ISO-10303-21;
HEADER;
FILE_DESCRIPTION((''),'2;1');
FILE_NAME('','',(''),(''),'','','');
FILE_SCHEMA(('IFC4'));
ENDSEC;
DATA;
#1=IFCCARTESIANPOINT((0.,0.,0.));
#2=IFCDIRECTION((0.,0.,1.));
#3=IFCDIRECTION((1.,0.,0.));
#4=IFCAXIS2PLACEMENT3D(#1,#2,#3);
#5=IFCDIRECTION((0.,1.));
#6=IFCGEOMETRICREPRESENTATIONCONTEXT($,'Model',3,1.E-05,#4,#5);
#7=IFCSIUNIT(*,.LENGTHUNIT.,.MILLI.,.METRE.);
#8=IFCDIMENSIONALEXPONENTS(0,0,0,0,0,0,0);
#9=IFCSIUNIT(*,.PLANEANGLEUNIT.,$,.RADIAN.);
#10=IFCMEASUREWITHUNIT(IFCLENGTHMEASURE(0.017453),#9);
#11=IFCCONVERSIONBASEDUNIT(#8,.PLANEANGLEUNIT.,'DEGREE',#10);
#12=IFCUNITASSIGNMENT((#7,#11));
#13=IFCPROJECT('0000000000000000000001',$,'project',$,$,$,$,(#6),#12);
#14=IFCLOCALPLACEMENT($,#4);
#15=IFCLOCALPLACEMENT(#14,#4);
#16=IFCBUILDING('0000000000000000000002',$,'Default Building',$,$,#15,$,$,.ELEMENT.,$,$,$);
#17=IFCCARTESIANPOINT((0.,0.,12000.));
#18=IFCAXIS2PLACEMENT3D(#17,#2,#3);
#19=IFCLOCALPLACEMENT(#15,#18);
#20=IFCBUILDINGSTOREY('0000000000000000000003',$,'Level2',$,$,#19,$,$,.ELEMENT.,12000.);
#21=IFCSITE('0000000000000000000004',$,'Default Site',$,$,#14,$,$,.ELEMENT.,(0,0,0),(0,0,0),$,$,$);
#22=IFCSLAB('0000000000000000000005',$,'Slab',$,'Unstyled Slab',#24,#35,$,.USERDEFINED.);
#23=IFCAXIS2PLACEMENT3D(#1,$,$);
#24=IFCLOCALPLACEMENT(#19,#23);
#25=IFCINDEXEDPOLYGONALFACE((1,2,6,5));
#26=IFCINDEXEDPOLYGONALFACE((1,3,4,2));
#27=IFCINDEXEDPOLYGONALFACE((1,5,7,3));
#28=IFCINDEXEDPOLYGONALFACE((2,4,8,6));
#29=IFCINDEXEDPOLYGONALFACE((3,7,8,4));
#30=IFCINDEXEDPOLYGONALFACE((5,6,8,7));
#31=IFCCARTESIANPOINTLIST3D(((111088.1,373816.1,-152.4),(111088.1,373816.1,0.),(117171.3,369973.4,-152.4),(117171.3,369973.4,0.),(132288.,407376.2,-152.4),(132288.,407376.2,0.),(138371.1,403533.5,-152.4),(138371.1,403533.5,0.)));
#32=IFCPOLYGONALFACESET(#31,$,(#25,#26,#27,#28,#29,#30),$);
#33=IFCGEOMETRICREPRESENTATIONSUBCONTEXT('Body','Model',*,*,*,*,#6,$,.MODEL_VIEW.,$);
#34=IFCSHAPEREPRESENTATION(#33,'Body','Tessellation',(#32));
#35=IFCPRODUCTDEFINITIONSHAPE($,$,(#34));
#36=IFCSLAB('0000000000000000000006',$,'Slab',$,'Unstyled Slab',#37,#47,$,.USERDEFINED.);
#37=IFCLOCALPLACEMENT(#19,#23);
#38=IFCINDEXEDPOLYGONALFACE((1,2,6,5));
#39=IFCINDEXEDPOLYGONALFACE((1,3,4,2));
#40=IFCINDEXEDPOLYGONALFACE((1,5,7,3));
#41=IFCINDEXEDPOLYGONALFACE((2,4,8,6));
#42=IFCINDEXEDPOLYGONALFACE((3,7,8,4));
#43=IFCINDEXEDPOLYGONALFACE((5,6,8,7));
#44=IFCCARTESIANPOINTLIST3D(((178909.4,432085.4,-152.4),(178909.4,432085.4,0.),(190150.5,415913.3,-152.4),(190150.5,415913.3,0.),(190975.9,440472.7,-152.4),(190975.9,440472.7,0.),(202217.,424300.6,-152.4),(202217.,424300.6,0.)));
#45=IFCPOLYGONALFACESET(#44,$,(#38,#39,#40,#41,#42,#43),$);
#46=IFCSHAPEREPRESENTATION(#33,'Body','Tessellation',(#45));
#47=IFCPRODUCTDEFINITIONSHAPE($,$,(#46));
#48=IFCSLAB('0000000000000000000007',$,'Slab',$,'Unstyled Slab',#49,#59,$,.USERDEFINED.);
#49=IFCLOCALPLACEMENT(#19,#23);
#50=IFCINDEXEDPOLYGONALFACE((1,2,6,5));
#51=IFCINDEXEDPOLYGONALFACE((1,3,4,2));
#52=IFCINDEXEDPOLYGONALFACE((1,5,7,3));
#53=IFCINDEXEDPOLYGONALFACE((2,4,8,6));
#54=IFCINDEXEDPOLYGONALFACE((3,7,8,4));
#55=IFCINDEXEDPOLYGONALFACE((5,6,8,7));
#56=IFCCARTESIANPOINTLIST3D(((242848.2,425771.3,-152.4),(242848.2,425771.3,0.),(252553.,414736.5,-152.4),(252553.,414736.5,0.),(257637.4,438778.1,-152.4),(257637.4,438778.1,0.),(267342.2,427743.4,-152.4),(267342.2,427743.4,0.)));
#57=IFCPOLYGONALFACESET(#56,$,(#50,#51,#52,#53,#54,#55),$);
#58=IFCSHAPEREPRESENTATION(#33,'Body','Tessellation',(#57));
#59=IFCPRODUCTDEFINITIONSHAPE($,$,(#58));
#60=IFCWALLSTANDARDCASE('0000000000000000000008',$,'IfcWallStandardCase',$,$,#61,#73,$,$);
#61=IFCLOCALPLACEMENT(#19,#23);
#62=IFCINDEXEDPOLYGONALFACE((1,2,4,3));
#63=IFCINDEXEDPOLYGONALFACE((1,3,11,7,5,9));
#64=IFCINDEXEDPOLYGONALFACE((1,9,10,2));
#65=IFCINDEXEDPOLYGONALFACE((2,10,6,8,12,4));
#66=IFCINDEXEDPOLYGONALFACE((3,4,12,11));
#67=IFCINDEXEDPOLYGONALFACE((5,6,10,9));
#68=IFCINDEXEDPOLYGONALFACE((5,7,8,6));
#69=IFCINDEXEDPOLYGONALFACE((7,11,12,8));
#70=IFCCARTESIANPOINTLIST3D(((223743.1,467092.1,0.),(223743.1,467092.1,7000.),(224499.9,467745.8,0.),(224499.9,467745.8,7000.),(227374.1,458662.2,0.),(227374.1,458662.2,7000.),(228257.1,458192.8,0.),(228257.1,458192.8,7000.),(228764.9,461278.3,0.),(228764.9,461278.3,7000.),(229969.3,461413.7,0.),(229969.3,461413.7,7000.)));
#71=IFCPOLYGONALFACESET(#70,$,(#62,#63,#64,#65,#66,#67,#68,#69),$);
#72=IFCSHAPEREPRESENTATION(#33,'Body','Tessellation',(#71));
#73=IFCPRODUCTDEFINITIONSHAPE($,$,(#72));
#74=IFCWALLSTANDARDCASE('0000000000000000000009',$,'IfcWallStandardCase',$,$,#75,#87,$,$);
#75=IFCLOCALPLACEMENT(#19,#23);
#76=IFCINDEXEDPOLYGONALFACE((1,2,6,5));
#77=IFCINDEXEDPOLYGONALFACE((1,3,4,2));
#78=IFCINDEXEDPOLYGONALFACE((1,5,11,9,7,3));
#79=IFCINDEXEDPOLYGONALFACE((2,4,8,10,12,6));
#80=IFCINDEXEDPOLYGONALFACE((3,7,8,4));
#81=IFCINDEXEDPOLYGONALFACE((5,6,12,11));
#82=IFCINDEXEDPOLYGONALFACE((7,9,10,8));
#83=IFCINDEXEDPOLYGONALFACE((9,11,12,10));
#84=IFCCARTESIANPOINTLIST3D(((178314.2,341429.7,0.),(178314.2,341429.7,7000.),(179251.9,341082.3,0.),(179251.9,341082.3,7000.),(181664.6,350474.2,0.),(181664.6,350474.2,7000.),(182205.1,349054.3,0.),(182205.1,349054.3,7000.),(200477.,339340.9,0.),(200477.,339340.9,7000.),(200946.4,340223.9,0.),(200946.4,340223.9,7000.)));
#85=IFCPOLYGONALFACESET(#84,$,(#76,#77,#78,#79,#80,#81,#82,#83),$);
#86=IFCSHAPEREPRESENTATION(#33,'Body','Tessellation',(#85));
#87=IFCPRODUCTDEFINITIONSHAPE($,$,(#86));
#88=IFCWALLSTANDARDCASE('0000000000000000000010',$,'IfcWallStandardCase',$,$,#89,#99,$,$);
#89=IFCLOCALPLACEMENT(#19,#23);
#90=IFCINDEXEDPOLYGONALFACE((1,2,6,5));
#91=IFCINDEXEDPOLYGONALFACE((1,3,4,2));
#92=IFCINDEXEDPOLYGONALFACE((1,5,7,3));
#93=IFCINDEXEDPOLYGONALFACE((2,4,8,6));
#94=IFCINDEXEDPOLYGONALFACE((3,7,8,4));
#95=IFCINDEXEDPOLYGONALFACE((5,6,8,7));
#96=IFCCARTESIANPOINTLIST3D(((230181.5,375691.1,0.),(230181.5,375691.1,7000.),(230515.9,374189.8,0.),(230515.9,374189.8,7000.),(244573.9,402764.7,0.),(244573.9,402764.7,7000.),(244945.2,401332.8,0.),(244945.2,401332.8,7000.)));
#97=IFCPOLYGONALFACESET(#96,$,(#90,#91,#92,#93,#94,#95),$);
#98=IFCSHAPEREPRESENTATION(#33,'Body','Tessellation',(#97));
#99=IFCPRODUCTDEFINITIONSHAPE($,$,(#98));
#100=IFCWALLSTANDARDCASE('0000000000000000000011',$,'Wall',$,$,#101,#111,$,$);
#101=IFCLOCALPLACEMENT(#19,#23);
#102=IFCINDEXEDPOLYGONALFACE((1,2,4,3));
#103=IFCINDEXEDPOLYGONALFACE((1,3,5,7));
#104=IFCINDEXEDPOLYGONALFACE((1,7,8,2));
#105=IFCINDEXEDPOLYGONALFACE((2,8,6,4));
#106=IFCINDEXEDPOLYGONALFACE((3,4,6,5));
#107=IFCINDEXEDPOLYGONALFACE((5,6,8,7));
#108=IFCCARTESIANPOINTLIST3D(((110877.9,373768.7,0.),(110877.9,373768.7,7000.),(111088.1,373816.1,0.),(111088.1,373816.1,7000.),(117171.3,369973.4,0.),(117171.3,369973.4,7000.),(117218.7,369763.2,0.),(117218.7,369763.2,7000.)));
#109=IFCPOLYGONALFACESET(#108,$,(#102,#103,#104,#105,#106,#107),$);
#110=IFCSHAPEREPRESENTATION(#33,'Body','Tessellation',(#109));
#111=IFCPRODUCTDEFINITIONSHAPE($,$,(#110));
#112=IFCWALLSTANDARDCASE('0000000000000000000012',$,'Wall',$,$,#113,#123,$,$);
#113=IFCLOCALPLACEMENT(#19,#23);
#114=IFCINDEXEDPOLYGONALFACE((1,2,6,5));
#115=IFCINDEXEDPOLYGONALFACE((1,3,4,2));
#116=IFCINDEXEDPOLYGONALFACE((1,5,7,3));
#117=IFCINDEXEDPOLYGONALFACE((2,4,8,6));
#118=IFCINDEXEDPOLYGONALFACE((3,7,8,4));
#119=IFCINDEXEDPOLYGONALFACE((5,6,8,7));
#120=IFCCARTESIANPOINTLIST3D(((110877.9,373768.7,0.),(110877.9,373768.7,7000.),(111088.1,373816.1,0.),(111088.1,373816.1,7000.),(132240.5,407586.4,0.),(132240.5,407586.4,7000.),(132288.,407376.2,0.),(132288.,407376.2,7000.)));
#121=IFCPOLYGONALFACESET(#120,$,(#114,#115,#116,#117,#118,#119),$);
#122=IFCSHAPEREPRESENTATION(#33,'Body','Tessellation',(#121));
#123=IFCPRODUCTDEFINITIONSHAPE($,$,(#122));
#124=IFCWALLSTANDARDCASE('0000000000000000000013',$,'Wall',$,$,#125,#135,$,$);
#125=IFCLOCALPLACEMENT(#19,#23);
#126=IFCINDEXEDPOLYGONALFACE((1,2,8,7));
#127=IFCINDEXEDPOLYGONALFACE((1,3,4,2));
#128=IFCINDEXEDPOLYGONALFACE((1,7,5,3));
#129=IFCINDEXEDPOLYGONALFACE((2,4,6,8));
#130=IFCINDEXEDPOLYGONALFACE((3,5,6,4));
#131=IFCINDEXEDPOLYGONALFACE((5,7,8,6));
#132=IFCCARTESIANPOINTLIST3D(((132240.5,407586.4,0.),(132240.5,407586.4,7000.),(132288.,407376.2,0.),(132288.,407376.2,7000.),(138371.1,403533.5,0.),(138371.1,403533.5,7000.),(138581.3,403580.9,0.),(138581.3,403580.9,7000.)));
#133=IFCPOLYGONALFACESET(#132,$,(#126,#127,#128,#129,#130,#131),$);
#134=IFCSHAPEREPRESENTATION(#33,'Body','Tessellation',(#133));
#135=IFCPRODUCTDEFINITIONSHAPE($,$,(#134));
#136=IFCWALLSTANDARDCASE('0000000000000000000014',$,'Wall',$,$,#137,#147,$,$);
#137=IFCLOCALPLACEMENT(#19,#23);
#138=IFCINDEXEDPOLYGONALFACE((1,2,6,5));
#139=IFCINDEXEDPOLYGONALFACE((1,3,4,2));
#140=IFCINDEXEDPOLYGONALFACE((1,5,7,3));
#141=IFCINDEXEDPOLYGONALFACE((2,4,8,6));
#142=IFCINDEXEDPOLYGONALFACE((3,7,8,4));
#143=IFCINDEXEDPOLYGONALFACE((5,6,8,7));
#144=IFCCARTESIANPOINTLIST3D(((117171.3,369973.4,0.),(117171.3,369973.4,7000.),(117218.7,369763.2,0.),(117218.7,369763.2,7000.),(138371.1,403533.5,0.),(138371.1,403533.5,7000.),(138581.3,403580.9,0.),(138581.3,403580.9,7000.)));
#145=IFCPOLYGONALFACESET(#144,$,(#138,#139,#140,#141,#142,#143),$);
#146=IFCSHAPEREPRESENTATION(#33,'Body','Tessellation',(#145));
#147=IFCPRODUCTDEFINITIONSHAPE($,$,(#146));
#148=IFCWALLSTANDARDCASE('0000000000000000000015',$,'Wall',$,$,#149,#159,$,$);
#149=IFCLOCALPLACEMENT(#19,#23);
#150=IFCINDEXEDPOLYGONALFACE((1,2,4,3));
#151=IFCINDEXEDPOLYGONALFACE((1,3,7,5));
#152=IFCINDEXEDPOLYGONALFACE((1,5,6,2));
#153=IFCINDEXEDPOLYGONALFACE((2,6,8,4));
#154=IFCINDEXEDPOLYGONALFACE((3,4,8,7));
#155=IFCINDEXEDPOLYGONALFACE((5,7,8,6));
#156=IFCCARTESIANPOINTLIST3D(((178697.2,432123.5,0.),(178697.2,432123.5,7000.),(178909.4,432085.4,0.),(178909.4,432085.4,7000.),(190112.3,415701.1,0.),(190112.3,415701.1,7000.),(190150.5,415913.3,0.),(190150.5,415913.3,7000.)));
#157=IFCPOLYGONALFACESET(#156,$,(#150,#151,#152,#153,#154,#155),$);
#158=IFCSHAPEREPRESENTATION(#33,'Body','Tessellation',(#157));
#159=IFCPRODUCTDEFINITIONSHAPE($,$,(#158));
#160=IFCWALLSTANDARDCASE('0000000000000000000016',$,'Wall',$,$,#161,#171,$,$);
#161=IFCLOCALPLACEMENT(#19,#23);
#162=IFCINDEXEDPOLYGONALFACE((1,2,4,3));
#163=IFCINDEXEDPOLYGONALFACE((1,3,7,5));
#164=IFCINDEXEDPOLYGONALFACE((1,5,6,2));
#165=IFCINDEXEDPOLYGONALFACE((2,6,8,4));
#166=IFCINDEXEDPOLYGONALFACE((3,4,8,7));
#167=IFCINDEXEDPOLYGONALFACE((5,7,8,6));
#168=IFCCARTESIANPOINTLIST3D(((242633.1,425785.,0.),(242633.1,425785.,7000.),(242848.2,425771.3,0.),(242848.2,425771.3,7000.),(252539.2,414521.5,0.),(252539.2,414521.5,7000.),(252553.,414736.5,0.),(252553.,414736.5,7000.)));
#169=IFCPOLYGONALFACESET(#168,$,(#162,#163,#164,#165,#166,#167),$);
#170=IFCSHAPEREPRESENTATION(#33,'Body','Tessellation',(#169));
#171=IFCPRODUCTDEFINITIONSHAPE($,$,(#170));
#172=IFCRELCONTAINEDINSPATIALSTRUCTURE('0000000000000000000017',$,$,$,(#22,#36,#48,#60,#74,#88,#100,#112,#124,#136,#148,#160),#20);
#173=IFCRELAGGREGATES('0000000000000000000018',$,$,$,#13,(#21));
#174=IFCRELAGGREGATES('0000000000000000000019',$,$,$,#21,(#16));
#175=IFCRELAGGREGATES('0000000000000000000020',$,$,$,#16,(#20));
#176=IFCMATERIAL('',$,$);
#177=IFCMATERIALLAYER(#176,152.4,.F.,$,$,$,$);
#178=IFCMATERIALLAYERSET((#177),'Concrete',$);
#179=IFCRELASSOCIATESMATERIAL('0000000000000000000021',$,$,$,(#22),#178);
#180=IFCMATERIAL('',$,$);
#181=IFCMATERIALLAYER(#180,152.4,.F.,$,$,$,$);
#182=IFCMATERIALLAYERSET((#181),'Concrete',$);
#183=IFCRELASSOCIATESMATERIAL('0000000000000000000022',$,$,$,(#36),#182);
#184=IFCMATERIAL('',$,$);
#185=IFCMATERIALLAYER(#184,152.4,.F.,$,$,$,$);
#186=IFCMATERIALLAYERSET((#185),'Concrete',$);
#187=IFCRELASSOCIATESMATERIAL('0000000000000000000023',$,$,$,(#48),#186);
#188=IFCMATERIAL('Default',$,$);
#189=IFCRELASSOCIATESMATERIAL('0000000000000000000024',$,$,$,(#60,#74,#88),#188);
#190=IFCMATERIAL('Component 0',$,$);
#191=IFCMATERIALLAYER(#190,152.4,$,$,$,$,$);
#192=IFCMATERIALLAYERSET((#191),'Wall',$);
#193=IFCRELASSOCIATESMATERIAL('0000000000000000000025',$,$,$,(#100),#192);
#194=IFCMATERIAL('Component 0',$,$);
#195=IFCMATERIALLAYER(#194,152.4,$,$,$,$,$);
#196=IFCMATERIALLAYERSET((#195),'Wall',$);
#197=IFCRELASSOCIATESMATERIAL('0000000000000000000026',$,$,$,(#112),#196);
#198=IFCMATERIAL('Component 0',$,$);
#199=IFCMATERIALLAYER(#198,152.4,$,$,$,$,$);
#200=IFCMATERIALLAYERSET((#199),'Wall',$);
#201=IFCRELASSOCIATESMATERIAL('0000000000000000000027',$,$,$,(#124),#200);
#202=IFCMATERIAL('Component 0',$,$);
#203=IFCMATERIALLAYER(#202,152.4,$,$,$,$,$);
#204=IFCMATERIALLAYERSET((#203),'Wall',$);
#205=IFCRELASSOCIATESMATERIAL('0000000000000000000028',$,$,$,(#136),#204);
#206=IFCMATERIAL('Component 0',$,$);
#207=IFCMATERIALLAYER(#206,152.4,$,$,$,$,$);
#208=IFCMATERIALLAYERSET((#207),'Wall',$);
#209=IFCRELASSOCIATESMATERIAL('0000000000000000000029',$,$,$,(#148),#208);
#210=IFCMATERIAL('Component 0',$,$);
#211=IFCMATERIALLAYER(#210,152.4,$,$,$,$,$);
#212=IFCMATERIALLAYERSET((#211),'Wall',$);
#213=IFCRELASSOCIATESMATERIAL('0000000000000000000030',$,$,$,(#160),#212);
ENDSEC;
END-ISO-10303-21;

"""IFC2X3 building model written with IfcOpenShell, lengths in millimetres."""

from ifc_helpers import new_model, entity, si_unit, converted_unit, direction, frame, origin_with_axes, place, context, subcontext, project, spatial, polyline, outline, extrude, material, layer, layer_set, layer_usage, element, save


model = new_model("IFC2X3")

# Units and contexts
model_context = context("Model", 3, precision=1e-05, world=origin_with_axes(), true_north=direction((0.0, 1.0)))
body_context = subcontext(model_context, "Body", "Model", "MODEL_VIEW")
ifc_project = project(units=[si_unit("LENGTHUNIT", "METRE", prefix="MILLI"), converted_unit("PLANEANGLEUNIT", "DEGREE", entity("IfcLengthMeasure", 0.017453), si_unit("PLANEANGLEUNIT", "RADIAN"), dimensions=[0, 0, 0, 0, 0, 0, 0])], contexts=[model_context])

# Site, building, storey
site_placement = place(None, origin_with_axes())
site = spatial("IfcSite", under=ifc_project, at=site_placement, Name="Default Site", CompositionType="ELEMENT", RefLatitude=(0, 0, 0), RefLongitude=(0, 0, 0))
building_placement = place(site_placement, origin_with_axes())
building = spatial("IfcBuilding", under=site, at=building_placement, Name="Default Building", CompositionType="ELEMENT")
storey_placement = place(building_placement, frame((0.0, 0.0, 12000.0), z_axis=(0.0, 0.0, 1.0), x_axis=(1.0, 0.0, 0.0)))
storey = spatial("IfcBuildingStorey", under=building, at=storey_placement, Name="Level2", CompositionType="ELEMENT", Elevation=12000.0)

# Slabs
ifc_material_1 = material(Name="")
ifc_layer_1 = layer(ifc_material_1, 152.4, ventilated=False)
ifc_layer_set_1 = layer_set([ifc_layer_1], Name="Concrete")
ifc_layer_usage_1 = layer_usage(ifc_layer_set_1, "AXIS3", "NEGATIVE", 0.0)
slab_1_placement = place(storey_placement, frame((0.0, 0.0, -12000.0), z_axis=(0.0, 0.0, 1.0), x_axis=(1.0, 0.0, 0.0)))
element("IfcSlab", 1, at=slab_1_placement, inside=storey, material=ifc_layer_usage_1, Name="Slab", ObjectType="Unstyled Slab", PredefinedType="USERDEFINED", context=body_context, shape_type="SweptSolid", body=[
    extrude(outline(polyline([(0.0, 39695.2), (7195.2, 39695.2), (7195.2, 0.0), (0.0, 0.0), (0.0, 39695.2)])), frame((117171.3, 369973.4, 11847.6), z_axis=(0.0, 0.0, -1.0), x_axis=(-0.845443, 0.534065, 0.0)), (0.0, 0.0, -1.0), 152.4),
])
ifc_material_2 = material(Name="")
ifc_layer_2 = layer(ifc_material_2, 152.4, ventilated=False)
ifc_layer_set_2 = layer_set([ifc_layer_2], Name="Concrete")
ifc_layer_usage_2 = layer_usage(ifc_layer_set_2, "AXIS3", "NEGATIVE", 0.0)
slab_2_placement = place(storey_placement, frame((0.0, 0.0, -12000.0), z_axis=(0.0, 0.0, 1.0), x_axis=(1.0, 0.0, 0.0)))
element("IfcSlab", 2, at=slab_2_placement, inside=storey, material=ifc_layer_usage_2, Name="Slab", ObjectType="Unstyled Slab", PredefinedType="USERDEFINED", context=body_context, shape_type="SweptSolid", body=[
    extrude(outline(polyline([(0.0, 19695.2), (14695.2, 19695.2), (14695.2, 0.0), (0.0, 0.0), (0.0, 19695.2)])), frame((178909.4, 432085.4, 11847.6), z_axis=(0.0, 0.0, -1.0), x_axis=(0.82112, 0.570755, 0.0)), (0.0, 0.0, -1.0), 152.4),
])
ifc_material_3 = material(Name="")
ifc_layer_3 = layer(ifc_material_3, 152.4, ventilated=False)
ifc_layer_set_3 = layer_set([ifc_layer_3], Name="Concrete")
ifc_layer_usage_3 = layer_usage(ifc_layer_set_3, "AXIS3", "NEGATIVE", 0.0)
slab_3_placement = place(storey_placement, frame((0.0, 0.0, -12000.0), z_axis=(0.0, 0.0, 1.0), x_axis=(1.0, 0.0, 0.0)))
element("IfcSlab", 3, at=slab_3_placement, inside=storey, material=ifc_layer_usage_3, Name="Slab", ObjectType="Unstyled Slab", PredefinedType="USERDEFINED", context=body_context, shape_type="SweptSolid", body=[
    extrude(outline(polyline([(0.0, 19695.2), (14695.2, 19695.2), (14695.2, 0.0), (0.0, 0.0), (0.0, 19695.2)])), frame((252553.0, 414736.5, 11847.6), z_axis=(0.0, 0.0, -1.0), x_axis=(-0.660409, 0.750906, 0.0)), (0.0, 0.0, -1.0), 152.4),
])

# Walls
ifc_material_4 = material(Name="Default")
wall_1_placement = place(storey_placement, frame((0.0, 0.0, -12000.0), z_axis=(0.0, 0.0, 1.0), x_axis=(1.0, 0.0, 0.0)))
element("IfcWallStandardCase", 4, at=wall_1_placement, inside=storey, material=ifc_material_4, Name="IfcWallStandardCase", context=body_context, shape_type="SweptSolid", body=[
    extrude(outline(polyline([(227374.1, 458662.2), (228764.9, 461278.3), (223743.1, 467092.1), (224499.9, 467745.8), (229969.3, 461413.7), (228257.1, 458192.8), (227374.1, 458662.2)])), frame((0.0, 0.0, 12000.0), z_axis=(0.0, 0.0, 1.0), x_axis=(1.0, 0.0, 0.0)), (0.0, 0.0, 1.0), 7000.0),
])
wall_2_placement = place(storey_placement, frame((0.0, 0.0, -12000.0), z_axis=(0.0, 0.0, 1.0), x_axis=(1.0, 0.0, 0.0)))
element("IfcWallStandardCase", 5, at=wall_2_placement, inside=storey, material=ifc_material_4, Name="IfcWallStandardCase", context=body_context, shape_type="SweptSolid", body=[
    extrude(outline(polyline([(178314.2, 341429.7), (181664.6, 350474.2), (200946.4, 340223.9), (200477.0, 339340.9), (182205.1, 349054.3), (179251.9, 341082.3), (178314.2, 341429.7)])), frame((0.0, 0.0, 12000.0), z_axis=(0.0, 0.0, 1.0), x_axis=(1.0, 0.0, 0.0)), (0.0, 0.0, 1.0), 7000.0),
])
wall_3_placement = place(storey_placement, frame((0.0, 0.0, -12000.0), z_axis=(0.0, 0.0, 1.0), x_axis=(1.0, 0.0, 0.0)))
element("IfcWallStandardCase", 6, at=wall_3_placement, inside=storey, material=ifc_material_4, Name="IfcWallStandardCase", context=body_context, shape_type="SweptSolid", body=[
    extrude(outline(polyline([(244945.2, 401332.8), (244573.9, 402764.7), (230181.5, 375691.1), (230515.9, 374189.8), (244945.2, 401332.8)])), frame((0.0, 0.0, 12000.0), z_axis=(0.0, 0.0, 1.0), x_axis=(1.0, 0.0, 0.0)), (0.0, 0.0, 1.0), 7000.0),
])
ifc_material_5 = material(Name="Component 0")
ifc_layer_4 = layer(ifc_material_5, 152.4)
ifc_layer_set_4 = layer_set([ifc_layer_4], Name="Wall")
ifc_layer_usage_4 = layer_usage(ifc_layer_set_4, "AXIS2", "POSITIVE", -76.2)
wall_4_placement = place(storey_placement, frame((117195.0, 369868.3, 0.0), z_axis=(0.0, 0.0, 1.0), x_axis=(-0.845443, 0.534065, 0.0)))
element("IfcWallStandardCase", 7, at=wall_4_placement, inside=storey, material=ifc_layer_usage_4, Name="Wall", context=body_context, shape_type="SweptSolid", body=[
    extrude(outline(polyline([(76.2, -76.2), (-76.2, 76.2), (7423.8, 76.2), (7271.4, -76.2), (76.2, -76.2)])), origin_with_axes(), (0.0, 0.0, 1.0), 7000.0),
])
ifc_material_6 = material(Name="Component 0")
ifc_layer_5 = layer(ifc_material_6, 152.4)
ifc_layer_set_5 = layer_set([ifc_layer_5], Name="Wall")
ifc_layer_usage_5 = layer_usage(ifc_layer_set_5, "AXIS2", "POSITIVE", -76.2)
wall_5_placement = place(storey_placement, frame((110983.0, 373792.4, 0.0), z_axis=(0.0, 0.0, 1.0), x_axis=(0.534065, 0.845443, 0.0)))
element("IfcWallStandardCase", 8, at=wall_5_placement, inside=storey, material=ifc_layer_usage_5, Name="Wall", context=body_context, shape_type="SweptSolid", body=[
    extrude(outline(polyline([(76.2, -76.2), (-76.2, 76.2), (39923.8, 76.2), (39771.4, -76.2), (76.2, -76.2)])), origin_with_axes(), (0.0, 0.0, 1.0), 7000.0),
])
ifc_material_7 = material(Name="Component 0")
ifc_layer_6 = layer(ifc_material_7, 152.4)
ifc_layer_set_6 = layer_set([ifc_layer_6], Name="Wall")
ifc_layer_usage_6 = layer_usage(ifc_layer_set_6, "AXIS2", "POSITIVE", -76.2)
wall_6_placement = place(storey_placement, frame((132264.2, 407481.3, 0.0), z_axis=(0.0, 0.0, 1.0), x_axis=(0.845443, -0.534065, 0.0)))
element("IfcWallStandardCase", 9, at=wall_6_placement, inside=storey, material=ifc_layer_usage_6, Name="Wall", context=body_context, shape_type="SweptSolid", body=[
    extrude(outline(polyline([(76.2, -76.2), (-76.2, 76.2), (7423.8, 76.2), (7271.4, -76.2), (76.2, -76.2)])), origin_with_axes(), (0.0, 0.0, 1.0), 7000.0),
])
ifc_material_8 = material(Name="Component 0")
ifc_layer_7 = layer(ifc_material_8, 152.4)
ifc_layer_set_7 = layer_set([ifc_layer_7], Name="Wall")
ifc_layer_usage_7 = layer_usage(ifc_layer_set_7, "AXIS2", "POSITIVE", -76.2)
wall_7_placement = place(storey_placement, frame((138476.2, 403557.2, 0.0), z_axis=(0.0, 0.0, 1.0), x_axis=(-0.534065, -0.845443, 0.0)))
element("IfcWallStandardCase", 10, at=wall_7_placement, inside=storey, material=ifc_layer_usage_7, Name="Wall", context=body_context, shape_type="SweptSolid", body=[
    extrude(outline(polyline([(76.2, -76.2), (-76.2, 76.2), (39923.8, 76.2), (39771.4, -76.2), (76.2, -76.2)])), origin_with_axes(), (0.0, 0.0, 1.0), 7000.0),
])
ifc_material_9 = material(Name="Component 0")
ifc_layer_8 = layer(ifc_material_9, 152.4)
ifc_layer_set_8 = layer_set([ifc_layer_8], Name="Wall")
ifc_layer_usage_8 = layer_usage(ifc_layer_set_8, "AXIS2", "POSITIVE", -76.2)
wall_8_placement = place(storey_placement, frame((190131.4, 415807.2, 0.0), z_axis=(0.0, 0.0, 1.0), x_axis=(-0.570755, 0.82112, 0.0)))
element("IfcWallStandardCase", 11, at=wall_8_placement, inside=storey, material=ifc_layer_usage_8, Name="Wall", context=body_context, shape_type="SweptSolid", body=[
    extrude(outline(polyline([(76.2, -76.2), (-76.2, 76.2), (19923.8, 76.2), (19771.4, -76.2), (76.2, -76.2)])), origin_with_axes(), (0.0, 0.0, 1.0), 7000.0),
])
ifc_material_10 = material(Name="Component 0")
ifc_layer_9 = layer(ifc_material_10, 152.4)
ifc_layer_set_9 = layer_set([ifc_layer_9], Name="Wall")
ifc_layer_usage_9 = layer_usage(ifc_layer_set_9, "AXIS2", "POSITIVE", -76.2)
wall_9_placement = place(storey_placement, frame((252546.1, 414629.0, 0.0), z_axis=(0.0, 0.0, 1.0), x_axis=(-0.660409, 0.750906, 0.0)))
element("IfcWallStandardCase", 12, at=wall_9_placement, inside=storey, material=ifc_layer_usage_9, Name="Wall", context=body_context, shape_type="SweptSolid", body=[
    extrude(outline(polyline([(76.2, -76.2), (-76.2, 76.2), (14923.8, 76.2), (14771.4, -76.2), (76.2, -76.2)])), origin_with_axes(), (0.0, 0.0, 1.0), 7000.0),
])

save(model, "model.ifc")
